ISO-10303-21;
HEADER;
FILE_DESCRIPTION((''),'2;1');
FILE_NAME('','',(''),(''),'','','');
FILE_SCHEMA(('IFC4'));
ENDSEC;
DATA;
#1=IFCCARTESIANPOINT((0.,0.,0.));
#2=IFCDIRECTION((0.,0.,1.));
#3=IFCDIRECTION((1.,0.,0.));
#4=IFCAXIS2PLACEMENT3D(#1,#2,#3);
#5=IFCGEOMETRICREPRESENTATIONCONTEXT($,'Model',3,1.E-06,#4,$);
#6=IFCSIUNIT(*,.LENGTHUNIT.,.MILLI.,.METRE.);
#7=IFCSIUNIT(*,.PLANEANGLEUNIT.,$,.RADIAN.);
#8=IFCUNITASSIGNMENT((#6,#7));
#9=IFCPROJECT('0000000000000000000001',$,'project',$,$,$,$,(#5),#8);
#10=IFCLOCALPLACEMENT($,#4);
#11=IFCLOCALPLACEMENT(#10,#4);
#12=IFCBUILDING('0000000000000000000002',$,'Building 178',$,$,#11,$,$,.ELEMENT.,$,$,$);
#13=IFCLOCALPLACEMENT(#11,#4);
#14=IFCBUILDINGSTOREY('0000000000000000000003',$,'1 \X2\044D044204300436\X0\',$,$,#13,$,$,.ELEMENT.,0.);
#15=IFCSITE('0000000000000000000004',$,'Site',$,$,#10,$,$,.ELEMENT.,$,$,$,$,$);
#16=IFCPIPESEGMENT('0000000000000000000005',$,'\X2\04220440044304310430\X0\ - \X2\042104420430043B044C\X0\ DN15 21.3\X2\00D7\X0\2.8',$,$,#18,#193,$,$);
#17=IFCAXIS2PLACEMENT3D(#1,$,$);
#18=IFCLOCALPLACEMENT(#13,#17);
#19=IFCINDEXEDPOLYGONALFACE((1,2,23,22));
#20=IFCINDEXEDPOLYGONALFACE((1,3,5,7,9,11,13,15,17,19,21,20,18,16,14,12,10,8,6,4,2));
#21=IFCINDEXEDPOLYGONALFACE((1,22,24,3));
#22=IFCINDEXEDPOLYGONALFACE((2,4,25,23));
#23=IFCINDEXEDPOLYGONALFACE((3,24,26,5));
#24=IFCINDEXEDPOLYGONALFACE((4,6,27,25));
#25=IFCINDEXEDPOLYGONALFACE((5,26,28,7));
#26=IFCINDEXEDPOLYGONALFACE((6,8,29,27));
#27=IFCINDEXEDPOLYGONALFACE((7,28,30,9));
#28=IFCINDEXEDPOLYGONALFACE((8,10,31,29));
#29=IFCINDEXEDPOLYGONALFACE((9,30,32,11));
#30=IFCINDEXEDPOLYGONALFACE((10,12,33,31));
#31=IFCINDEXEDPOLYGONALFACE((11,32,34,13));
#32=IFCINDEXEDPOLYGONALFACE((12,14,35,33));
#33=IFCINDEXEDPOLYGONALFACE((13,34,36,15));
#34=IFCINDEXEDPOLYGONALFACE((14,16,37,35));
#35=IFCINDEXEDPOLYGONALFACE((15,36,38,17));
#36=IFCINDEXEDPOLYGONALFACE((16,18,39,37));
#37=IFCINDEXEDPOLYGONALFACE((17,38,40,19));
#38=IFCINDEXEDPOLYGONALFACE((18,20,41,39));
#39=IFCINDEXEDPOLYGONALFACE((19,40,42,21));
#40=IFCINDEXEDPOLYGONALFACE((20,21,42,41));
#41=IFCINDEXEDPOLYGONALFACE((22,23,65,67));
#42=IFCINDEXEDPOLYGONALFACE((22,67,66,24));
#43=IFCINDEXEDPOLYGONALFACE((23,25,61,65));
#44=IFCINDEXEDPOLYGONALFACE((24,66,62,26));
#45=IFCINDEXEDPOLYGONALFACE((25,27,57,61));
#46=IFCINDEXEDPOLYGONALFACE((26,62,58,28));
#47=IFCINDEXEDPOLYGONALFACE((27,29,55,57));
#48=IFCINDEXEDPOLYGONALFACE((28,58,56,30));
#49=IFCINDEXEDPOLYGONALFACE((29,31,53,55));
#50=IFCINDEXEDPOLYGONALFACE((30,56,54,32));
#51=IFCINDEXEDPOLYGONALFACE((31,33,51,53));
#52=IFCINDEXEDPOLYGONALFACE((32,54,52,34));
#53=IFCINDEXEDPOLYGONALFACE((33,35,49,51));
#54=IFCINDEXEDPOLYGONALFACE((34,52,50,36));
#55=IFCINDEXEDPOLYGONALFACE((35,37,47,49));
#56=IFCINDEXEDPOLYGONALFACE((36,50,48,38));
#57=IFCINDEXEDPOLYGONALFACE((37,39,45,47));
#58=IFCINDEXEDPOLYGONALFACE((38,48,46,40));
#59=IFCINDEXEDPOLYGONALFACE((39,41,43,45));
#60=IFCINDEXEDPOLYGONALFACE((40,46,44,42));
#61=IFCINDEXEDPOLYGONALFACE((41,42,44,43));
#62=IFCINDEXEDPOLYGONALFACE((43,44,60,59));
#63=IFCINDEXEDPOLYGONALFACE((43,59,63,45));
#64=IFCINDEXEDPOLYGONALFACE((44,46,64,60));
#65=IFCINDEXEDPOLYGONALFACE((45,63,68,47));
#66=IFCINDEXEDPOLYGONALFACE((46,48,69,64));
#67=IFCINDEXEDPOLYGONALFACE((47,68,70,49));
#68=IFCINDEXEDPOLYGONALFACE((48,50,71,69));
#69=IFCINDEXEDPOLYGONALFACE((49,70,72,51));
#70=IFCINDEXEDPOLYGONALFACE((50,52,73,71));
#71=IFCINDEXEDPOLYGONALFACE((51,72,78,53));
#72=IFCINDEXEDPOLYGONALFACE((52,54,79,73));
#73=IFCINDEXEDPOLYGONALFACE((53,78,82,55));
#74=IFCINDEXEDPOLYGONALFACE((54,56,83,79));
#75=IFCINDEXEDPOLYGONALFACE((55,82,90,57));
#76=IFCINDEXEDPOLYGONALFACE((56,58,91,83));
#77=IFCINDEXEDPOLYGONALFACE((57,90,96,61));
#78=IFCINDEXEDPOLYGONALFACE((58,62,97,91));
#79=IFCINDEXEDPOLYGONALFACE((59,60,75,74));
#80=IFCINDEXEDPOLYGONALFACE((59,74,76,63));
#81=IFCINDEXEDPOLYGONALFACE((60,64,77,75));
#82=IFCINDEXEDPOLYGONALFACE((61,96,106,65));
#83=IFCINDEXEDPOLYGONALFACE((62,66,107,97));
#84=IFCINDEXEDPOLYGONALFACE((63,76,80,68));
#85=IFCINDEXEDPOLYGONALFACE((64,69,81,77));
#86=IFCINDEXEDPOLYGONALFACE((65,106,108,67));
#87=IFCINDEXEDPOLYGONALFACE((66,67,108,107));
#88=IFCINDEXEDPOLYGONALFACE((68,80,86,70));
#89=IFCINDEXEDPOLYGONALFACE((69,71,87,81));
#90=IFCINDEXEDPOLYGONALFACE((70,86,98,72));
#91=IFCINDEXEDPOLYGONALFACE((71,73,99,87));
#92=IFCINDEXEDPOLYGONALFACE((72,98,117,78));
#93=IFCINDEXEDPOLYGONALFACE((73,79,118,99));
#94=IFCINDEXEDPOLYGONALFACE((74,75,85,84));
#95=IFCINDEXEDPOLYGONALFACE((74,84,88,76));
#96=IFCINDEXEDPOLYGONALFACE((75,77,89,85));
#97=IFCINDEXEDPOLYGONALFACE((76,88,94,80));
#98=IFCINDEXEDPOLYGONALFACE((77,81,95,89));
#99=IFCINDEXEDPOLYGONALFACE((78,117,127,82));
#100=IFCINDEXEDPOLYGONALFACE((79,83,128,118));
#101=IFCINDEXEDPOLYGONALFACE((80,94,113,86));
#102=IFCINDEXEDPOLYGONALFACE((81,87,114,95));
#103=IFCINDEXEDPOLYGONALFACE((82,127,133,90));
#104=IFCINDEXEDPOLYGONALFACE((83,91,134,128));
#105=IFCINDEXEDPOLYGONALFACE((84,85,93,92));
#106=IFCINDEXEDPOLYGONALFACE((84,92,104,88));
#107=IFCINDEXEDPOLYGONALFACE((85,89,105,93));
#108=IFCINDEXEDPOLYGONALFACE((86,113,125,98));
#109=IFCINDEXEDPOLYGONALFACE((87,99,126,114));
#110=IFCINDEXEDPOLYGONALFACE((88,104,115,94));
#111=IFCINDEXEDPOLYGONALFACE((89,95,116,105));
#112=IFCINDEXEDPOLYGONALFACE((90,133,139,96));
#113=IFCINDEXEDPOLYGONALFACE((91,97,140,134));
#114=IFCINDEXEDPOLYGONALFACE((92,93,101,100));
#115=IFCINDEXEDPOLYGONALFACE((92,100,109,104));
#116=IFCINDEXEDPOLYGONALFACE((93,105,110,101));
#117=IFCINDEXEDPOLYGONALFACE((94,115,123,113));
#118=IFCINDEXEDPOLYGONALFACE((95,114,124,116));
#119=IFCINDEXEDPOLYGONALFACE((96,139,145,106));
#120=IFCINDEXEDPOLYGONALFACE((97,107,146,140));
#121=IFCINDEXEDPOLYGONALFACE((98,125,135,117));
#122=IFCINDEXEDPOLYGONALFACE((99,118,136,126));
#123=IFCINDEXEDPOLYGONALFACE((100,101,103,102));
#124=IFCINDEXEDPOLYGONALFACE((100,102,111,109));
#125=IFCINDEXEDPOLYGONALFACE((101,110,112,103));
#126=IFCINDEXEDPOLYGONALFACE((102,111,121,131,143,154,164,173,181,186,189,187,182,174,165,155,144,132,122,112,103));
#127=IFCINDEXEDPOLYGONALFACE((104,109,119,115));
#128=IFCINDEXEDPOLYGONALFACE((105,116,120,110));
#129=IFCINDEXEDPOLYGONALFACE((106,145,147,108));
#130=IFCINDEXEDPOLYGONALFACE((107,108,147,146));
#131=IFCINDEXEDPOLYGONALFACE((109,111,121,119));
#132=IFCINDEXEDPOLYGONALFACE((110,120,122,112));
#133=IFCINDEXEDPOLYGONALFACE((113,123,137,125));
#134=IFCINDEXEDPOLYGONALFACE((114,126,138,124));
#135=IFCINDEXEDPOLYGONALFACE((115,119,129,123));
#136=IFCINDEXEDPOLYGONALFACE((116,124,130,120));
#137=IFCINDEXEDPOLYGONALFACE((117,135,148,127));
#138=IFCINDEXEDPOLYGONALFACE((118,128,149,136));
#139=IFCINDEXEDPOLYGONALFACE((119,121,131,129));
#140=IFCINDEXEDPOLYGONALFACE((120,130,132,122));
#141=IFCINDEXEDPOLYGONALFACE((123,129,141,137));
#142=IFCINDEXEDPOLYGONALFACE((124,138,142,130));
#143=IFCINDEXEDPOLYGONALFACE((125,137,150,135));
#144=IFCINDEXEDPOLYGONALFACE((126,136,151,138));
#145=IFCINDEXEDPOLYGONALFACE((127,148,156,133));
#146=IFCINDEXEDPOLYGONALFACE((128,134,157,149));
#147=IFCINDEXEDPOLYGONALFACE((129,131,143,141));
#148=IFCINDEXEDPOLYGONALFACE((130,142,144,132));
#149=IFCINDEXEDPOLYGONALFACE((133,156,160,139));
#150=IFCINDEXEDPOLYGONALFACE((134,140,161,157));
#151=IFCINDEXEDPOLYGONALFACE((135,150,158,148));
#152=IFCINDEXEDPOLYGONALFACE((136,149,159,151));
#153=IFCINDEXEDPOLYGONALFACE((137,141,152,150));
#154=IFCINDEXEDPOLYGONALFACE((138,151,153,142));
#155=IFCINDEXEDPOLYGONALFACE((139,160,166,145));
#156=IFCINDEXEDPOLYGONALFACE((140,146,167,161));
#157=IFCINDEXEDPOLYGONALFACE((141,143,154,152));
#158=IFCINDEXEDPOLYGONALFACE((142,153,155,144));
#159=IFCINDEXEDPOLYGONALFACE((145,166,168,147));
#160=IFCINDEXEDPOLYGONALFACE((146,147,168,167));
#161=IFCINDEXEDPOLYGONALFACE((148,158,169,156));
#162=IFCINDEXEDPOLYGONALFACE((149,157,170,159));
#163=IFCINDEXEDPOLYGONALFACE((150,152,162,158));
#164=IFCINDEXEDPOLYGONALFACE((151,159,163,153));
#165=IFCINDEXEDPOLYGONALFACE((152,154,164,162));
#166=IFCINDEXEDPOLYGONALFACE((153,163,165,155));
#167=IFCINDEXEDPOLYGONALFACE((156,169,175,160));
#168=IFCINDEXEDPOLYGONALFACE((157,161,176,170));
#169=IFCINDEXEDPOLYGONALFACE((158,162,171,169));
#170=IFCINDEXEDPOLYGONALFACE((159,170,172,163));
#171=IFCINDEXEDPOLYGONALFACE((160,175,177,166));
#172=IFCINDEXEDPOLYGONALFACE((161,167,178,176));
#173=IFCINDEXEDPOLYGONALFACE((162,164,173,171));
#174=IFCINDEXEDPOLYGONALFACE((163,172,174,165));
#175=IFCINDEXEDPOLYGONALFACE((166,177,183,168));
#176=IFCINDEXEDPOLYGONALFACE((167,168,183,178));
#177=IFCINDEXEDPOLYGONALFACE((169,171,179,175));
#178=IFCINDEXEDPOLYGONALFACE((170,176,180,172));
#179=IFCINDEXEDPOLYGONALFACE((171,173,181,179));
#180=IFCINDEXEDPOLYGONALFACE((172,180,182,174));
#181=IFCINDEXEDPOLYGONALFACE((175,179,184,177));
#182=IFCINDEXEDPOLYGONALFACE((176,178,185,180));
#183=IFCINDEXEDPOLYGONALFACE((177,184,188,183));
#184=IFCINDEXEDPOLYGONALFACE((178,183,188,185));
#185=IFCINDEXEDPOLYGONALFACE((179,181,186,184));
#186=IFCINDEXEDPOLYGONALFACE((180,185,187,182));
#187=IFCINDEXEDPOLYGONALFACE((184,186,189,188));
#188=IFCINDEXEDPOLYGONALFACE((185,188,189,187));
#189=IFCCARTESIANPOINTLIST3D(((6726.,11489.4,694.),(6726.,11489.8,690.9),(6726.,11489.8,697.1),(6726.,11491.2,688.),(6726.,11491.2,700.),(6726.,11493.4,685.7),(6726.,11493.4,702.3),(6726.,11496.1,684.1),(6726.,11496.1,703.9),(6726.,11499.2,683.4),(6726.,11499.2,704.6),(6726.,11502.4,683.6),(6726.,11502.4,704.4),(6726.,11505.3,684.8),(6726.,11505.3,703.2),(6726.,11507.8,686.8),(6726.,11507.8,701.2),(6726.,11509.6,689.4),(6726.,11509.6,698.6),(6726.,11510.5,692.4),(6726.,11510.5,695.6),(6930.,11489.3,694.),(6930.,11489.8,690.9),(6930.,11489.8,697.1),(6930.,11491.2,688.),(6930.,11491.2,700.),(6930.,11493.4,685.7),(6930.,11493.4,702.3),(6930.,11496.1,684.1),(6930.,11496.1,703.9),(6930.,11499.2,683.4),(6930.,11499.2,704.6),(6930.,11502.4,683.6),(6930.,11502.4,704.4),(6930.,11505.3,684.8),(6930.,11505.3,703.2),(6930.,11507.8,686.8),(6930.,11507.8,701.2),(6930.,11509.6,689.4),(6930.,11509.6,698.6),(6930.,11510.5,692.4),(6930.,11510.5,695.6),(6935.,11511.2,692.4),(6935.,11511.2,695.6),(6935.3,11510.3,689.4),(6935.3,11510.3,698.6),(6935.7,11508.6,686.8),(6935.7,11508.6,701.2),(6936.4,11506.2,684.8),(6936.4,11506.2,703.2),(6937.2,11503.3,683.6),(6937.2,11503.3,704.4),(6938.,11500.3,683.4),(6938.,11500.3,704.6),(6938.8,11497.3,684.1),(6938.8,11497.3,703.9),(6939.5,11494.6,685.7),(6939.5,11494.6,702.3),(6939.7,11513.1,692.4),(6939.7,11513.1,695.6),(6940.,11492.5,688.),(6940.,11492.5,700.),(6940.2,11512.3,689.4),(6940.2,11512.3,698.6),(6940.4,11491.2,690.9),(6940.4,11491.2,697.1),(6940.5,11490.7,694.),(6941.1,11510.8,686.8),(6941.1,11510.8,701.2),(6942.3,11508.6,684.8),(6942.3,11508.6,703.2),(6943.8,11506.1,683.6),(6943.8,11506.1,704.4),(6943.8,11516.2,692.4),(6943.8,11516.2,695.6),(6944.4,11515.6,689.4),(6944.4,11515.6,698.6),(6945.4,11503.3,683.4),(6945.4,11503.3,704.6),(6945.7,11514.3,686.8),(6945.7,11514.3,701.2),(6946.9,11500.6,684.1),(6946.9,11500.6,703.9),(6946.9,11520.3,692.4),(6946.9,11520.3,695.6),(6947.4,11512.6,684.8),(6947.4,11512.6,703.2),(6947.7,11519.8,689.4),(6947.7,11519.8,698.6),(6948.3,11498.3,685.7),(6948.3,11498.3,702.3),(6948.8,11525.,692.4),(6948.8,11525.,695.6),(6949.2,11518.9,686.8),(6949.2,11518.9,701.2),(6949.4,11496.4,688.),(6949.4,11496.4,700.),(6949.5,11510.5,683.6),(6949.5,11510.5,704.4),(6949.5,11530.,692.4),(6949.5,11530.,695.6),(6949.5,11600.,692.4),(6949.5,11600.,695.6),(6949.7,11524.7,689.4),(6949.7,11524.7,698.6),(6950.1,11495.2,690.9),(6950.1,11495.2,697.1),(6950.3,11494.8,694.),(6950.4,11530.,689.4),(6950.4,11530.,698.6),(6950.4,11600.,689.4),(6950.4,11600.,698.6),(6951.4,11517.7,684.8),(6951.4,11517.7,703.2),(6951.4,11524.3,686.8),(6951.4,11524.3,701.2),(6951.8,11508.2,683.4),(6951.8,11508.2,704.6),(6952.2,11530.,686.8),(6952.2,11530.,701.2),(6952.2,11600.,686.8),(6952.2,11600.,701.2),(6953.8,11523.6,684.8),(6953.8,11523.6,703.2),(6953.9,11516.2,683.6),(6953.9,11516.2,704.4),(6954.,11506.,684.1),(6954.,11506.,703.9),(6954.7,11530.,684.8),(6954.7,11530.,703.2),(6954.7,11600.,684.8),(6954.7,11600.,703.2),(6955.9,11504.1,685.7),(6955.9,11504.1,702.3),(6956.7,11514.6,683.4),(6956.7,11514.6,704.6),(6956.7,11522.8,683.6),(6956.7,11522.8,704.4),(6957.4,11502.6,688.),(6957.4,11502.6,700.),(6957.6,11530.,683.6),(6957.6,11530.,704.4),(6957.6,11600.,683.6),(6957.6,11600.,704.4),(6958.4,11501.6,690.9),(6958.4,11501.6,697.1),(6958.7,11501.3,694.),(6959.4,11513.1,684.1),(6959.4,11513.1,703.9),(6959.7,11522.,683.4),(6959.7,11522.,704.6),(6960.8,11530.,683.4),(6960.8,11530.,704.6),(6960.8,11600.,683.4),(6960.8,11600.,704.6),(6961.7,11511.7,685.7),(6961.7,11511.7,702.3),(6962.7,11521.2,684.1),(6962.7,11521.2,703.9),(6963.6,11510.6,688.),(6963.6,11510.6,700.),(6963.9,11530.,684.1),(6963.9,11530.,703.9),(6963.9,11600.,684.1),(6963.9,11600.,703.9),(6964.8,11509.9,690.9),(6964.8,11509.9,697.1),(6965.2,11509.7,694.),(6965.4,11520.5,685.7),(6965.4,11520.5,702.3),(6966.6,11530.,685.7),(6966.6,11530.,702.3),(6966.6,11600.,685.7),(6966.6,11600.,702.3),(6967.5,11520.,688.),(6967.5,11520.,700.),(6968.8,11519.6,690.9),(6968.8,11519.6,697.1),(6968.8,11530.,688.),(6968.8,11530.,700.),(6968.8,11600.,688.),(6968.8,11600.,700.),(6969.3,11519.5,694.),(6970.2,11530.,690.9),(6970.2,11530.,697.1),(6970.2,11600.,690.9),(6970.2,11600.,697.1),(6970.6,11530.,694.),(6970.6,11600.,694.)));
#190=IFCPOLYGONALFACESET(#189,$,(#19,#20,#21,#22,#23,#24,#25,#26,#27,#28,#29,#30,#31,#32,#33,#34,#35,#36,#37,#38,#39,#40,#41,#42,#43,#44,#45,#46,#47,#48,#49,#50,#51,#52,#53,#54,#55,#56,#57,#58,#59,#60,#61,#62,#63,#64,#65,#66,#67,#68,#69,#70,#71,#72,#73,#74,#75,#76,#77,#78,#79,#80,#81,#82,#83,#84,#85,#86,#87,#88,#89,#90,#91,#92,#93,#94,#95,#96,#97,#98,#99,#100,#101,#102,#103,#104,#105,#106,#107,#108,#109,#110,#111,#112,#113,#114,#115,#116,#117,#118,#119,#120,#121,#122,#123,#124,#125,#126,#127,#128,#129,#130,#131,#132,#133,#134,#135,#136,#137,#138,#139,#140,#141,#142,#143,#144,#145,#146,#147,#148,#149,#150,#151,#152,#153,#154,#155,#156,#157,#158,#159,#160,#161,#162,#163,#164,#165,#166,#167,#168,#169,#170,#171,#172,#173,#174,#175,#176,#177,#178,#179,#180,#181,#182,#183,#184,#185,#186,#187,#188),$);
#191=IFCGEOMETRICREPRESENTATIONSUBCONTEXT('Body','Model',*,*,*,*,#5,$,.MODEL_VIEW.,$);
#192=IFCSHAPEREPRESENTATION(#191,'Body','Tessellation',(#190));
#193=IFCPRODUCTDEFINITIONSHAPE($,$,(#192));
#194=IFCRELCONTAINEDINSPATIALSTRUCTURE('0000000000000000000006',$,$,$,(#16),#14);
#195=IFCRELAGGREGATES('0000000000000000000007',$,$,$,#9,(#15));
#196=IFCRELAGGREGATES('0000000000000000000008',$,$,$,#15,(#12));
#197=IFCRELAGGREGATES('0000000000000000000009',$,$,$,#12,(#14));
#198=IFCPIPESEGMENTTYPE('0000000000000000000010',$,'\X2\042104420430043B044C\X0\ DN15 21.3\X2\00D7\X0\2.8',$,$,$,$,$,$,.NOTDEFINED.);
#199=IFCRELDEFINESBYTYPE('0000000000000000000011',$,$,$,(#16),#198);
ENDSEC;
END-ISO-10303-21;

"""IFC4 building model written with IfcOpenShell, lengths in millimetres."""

from ifc_helpers import new_model, entity, si_unit, frame, origin_with_axes, place, context, subcontext, project, spatial, source, transform, mapped, type_object, element, save


model = new_model("IFC4")

# Units and contexts
model_context = context("Model", 3, precision=1e-06, world=origin_with_axes())
body_context = subcontext(model_context, "Body", "Model", "MODEL_VIEW")
ifc_project = project(units=[si_unit("LENGTHUNIT", "METRE", prefix="MILLI"), si_unit("PLANEANGLEUNIT", "RADIAN")], contexts=[model_context])

# Site, building, storey
site_placement = place(None, origin_with_axes())
site = spatial("IfcSite", under=ifc_project, at=site_placement, Name="Site", CompositionType="ELEMENT")
building_placement = place(site_placement, origin_with_axes())
building = spatial("IfcBuilding", under=site, at=building_placement, Name="Building 178", CompositionType="ELEMENT")
storey_placement = place(building_placement, origin_with_axes())
storey = spatial("IfcBuildingStorey", under=building, at=storey_placement, Name="1 этаж", CompositionType="ELEMENT", Elevation=0.0)

# Pipe segment
pipe_segment_type = type_object("IfcPipeSegmentType", Name="Сталь DN15 21.3×2.8", PredefinedType="NOTDEFINED")
shared_shape_1 = source(origin_with_axes(), body_context, "Body", "AdvancedSweptSolid", [
    entity("IfcSweptDiskSolid", entity("IfcIndexedPolyCurve", entity("IfcCartesianPointList3D", [[0.0, 0.0, 0.0], [0.0, 0.0, -70.0], [8.8, 0.0, -91.2], [30.0, 0.0, -100.0], [234.0, 0.0, -100.0]]), [entity("IfcLineIndex", [1, 2]), entity("IfcArcIndex", [2, 3, 4]), entity("IfcLineIndex", [4, 5])]), 10.7),
])
for number, where, z_axis, x_axis, name in (
    (1, (6960.0, 11600.0, 694.0), (0.0, 1.0, 0.0), (-1.0, 0.0, 0.0), "Труба - Сталь DN15 21.3×2.8"),
):
    element("IfcPipeSegment", number, at=place(storey_placement, frame(where, z_axis=z_axis, x_axis=x_axis)), inside=storey, type_object=pipe_segment_type, Name=name, context=body_context, shape_type="MappedRepresentation", body=[
        mapped(shared_shape_1, transform((0.0, 0.0, 0.0), x_axis=(1.0, 0.0, 0.0), y_axis=(0.0, 1.0, 0.0), z_axis=(0.0, 0.0, 1.0), scale=1.0)),
    ])

save(model, "model.ifc")
